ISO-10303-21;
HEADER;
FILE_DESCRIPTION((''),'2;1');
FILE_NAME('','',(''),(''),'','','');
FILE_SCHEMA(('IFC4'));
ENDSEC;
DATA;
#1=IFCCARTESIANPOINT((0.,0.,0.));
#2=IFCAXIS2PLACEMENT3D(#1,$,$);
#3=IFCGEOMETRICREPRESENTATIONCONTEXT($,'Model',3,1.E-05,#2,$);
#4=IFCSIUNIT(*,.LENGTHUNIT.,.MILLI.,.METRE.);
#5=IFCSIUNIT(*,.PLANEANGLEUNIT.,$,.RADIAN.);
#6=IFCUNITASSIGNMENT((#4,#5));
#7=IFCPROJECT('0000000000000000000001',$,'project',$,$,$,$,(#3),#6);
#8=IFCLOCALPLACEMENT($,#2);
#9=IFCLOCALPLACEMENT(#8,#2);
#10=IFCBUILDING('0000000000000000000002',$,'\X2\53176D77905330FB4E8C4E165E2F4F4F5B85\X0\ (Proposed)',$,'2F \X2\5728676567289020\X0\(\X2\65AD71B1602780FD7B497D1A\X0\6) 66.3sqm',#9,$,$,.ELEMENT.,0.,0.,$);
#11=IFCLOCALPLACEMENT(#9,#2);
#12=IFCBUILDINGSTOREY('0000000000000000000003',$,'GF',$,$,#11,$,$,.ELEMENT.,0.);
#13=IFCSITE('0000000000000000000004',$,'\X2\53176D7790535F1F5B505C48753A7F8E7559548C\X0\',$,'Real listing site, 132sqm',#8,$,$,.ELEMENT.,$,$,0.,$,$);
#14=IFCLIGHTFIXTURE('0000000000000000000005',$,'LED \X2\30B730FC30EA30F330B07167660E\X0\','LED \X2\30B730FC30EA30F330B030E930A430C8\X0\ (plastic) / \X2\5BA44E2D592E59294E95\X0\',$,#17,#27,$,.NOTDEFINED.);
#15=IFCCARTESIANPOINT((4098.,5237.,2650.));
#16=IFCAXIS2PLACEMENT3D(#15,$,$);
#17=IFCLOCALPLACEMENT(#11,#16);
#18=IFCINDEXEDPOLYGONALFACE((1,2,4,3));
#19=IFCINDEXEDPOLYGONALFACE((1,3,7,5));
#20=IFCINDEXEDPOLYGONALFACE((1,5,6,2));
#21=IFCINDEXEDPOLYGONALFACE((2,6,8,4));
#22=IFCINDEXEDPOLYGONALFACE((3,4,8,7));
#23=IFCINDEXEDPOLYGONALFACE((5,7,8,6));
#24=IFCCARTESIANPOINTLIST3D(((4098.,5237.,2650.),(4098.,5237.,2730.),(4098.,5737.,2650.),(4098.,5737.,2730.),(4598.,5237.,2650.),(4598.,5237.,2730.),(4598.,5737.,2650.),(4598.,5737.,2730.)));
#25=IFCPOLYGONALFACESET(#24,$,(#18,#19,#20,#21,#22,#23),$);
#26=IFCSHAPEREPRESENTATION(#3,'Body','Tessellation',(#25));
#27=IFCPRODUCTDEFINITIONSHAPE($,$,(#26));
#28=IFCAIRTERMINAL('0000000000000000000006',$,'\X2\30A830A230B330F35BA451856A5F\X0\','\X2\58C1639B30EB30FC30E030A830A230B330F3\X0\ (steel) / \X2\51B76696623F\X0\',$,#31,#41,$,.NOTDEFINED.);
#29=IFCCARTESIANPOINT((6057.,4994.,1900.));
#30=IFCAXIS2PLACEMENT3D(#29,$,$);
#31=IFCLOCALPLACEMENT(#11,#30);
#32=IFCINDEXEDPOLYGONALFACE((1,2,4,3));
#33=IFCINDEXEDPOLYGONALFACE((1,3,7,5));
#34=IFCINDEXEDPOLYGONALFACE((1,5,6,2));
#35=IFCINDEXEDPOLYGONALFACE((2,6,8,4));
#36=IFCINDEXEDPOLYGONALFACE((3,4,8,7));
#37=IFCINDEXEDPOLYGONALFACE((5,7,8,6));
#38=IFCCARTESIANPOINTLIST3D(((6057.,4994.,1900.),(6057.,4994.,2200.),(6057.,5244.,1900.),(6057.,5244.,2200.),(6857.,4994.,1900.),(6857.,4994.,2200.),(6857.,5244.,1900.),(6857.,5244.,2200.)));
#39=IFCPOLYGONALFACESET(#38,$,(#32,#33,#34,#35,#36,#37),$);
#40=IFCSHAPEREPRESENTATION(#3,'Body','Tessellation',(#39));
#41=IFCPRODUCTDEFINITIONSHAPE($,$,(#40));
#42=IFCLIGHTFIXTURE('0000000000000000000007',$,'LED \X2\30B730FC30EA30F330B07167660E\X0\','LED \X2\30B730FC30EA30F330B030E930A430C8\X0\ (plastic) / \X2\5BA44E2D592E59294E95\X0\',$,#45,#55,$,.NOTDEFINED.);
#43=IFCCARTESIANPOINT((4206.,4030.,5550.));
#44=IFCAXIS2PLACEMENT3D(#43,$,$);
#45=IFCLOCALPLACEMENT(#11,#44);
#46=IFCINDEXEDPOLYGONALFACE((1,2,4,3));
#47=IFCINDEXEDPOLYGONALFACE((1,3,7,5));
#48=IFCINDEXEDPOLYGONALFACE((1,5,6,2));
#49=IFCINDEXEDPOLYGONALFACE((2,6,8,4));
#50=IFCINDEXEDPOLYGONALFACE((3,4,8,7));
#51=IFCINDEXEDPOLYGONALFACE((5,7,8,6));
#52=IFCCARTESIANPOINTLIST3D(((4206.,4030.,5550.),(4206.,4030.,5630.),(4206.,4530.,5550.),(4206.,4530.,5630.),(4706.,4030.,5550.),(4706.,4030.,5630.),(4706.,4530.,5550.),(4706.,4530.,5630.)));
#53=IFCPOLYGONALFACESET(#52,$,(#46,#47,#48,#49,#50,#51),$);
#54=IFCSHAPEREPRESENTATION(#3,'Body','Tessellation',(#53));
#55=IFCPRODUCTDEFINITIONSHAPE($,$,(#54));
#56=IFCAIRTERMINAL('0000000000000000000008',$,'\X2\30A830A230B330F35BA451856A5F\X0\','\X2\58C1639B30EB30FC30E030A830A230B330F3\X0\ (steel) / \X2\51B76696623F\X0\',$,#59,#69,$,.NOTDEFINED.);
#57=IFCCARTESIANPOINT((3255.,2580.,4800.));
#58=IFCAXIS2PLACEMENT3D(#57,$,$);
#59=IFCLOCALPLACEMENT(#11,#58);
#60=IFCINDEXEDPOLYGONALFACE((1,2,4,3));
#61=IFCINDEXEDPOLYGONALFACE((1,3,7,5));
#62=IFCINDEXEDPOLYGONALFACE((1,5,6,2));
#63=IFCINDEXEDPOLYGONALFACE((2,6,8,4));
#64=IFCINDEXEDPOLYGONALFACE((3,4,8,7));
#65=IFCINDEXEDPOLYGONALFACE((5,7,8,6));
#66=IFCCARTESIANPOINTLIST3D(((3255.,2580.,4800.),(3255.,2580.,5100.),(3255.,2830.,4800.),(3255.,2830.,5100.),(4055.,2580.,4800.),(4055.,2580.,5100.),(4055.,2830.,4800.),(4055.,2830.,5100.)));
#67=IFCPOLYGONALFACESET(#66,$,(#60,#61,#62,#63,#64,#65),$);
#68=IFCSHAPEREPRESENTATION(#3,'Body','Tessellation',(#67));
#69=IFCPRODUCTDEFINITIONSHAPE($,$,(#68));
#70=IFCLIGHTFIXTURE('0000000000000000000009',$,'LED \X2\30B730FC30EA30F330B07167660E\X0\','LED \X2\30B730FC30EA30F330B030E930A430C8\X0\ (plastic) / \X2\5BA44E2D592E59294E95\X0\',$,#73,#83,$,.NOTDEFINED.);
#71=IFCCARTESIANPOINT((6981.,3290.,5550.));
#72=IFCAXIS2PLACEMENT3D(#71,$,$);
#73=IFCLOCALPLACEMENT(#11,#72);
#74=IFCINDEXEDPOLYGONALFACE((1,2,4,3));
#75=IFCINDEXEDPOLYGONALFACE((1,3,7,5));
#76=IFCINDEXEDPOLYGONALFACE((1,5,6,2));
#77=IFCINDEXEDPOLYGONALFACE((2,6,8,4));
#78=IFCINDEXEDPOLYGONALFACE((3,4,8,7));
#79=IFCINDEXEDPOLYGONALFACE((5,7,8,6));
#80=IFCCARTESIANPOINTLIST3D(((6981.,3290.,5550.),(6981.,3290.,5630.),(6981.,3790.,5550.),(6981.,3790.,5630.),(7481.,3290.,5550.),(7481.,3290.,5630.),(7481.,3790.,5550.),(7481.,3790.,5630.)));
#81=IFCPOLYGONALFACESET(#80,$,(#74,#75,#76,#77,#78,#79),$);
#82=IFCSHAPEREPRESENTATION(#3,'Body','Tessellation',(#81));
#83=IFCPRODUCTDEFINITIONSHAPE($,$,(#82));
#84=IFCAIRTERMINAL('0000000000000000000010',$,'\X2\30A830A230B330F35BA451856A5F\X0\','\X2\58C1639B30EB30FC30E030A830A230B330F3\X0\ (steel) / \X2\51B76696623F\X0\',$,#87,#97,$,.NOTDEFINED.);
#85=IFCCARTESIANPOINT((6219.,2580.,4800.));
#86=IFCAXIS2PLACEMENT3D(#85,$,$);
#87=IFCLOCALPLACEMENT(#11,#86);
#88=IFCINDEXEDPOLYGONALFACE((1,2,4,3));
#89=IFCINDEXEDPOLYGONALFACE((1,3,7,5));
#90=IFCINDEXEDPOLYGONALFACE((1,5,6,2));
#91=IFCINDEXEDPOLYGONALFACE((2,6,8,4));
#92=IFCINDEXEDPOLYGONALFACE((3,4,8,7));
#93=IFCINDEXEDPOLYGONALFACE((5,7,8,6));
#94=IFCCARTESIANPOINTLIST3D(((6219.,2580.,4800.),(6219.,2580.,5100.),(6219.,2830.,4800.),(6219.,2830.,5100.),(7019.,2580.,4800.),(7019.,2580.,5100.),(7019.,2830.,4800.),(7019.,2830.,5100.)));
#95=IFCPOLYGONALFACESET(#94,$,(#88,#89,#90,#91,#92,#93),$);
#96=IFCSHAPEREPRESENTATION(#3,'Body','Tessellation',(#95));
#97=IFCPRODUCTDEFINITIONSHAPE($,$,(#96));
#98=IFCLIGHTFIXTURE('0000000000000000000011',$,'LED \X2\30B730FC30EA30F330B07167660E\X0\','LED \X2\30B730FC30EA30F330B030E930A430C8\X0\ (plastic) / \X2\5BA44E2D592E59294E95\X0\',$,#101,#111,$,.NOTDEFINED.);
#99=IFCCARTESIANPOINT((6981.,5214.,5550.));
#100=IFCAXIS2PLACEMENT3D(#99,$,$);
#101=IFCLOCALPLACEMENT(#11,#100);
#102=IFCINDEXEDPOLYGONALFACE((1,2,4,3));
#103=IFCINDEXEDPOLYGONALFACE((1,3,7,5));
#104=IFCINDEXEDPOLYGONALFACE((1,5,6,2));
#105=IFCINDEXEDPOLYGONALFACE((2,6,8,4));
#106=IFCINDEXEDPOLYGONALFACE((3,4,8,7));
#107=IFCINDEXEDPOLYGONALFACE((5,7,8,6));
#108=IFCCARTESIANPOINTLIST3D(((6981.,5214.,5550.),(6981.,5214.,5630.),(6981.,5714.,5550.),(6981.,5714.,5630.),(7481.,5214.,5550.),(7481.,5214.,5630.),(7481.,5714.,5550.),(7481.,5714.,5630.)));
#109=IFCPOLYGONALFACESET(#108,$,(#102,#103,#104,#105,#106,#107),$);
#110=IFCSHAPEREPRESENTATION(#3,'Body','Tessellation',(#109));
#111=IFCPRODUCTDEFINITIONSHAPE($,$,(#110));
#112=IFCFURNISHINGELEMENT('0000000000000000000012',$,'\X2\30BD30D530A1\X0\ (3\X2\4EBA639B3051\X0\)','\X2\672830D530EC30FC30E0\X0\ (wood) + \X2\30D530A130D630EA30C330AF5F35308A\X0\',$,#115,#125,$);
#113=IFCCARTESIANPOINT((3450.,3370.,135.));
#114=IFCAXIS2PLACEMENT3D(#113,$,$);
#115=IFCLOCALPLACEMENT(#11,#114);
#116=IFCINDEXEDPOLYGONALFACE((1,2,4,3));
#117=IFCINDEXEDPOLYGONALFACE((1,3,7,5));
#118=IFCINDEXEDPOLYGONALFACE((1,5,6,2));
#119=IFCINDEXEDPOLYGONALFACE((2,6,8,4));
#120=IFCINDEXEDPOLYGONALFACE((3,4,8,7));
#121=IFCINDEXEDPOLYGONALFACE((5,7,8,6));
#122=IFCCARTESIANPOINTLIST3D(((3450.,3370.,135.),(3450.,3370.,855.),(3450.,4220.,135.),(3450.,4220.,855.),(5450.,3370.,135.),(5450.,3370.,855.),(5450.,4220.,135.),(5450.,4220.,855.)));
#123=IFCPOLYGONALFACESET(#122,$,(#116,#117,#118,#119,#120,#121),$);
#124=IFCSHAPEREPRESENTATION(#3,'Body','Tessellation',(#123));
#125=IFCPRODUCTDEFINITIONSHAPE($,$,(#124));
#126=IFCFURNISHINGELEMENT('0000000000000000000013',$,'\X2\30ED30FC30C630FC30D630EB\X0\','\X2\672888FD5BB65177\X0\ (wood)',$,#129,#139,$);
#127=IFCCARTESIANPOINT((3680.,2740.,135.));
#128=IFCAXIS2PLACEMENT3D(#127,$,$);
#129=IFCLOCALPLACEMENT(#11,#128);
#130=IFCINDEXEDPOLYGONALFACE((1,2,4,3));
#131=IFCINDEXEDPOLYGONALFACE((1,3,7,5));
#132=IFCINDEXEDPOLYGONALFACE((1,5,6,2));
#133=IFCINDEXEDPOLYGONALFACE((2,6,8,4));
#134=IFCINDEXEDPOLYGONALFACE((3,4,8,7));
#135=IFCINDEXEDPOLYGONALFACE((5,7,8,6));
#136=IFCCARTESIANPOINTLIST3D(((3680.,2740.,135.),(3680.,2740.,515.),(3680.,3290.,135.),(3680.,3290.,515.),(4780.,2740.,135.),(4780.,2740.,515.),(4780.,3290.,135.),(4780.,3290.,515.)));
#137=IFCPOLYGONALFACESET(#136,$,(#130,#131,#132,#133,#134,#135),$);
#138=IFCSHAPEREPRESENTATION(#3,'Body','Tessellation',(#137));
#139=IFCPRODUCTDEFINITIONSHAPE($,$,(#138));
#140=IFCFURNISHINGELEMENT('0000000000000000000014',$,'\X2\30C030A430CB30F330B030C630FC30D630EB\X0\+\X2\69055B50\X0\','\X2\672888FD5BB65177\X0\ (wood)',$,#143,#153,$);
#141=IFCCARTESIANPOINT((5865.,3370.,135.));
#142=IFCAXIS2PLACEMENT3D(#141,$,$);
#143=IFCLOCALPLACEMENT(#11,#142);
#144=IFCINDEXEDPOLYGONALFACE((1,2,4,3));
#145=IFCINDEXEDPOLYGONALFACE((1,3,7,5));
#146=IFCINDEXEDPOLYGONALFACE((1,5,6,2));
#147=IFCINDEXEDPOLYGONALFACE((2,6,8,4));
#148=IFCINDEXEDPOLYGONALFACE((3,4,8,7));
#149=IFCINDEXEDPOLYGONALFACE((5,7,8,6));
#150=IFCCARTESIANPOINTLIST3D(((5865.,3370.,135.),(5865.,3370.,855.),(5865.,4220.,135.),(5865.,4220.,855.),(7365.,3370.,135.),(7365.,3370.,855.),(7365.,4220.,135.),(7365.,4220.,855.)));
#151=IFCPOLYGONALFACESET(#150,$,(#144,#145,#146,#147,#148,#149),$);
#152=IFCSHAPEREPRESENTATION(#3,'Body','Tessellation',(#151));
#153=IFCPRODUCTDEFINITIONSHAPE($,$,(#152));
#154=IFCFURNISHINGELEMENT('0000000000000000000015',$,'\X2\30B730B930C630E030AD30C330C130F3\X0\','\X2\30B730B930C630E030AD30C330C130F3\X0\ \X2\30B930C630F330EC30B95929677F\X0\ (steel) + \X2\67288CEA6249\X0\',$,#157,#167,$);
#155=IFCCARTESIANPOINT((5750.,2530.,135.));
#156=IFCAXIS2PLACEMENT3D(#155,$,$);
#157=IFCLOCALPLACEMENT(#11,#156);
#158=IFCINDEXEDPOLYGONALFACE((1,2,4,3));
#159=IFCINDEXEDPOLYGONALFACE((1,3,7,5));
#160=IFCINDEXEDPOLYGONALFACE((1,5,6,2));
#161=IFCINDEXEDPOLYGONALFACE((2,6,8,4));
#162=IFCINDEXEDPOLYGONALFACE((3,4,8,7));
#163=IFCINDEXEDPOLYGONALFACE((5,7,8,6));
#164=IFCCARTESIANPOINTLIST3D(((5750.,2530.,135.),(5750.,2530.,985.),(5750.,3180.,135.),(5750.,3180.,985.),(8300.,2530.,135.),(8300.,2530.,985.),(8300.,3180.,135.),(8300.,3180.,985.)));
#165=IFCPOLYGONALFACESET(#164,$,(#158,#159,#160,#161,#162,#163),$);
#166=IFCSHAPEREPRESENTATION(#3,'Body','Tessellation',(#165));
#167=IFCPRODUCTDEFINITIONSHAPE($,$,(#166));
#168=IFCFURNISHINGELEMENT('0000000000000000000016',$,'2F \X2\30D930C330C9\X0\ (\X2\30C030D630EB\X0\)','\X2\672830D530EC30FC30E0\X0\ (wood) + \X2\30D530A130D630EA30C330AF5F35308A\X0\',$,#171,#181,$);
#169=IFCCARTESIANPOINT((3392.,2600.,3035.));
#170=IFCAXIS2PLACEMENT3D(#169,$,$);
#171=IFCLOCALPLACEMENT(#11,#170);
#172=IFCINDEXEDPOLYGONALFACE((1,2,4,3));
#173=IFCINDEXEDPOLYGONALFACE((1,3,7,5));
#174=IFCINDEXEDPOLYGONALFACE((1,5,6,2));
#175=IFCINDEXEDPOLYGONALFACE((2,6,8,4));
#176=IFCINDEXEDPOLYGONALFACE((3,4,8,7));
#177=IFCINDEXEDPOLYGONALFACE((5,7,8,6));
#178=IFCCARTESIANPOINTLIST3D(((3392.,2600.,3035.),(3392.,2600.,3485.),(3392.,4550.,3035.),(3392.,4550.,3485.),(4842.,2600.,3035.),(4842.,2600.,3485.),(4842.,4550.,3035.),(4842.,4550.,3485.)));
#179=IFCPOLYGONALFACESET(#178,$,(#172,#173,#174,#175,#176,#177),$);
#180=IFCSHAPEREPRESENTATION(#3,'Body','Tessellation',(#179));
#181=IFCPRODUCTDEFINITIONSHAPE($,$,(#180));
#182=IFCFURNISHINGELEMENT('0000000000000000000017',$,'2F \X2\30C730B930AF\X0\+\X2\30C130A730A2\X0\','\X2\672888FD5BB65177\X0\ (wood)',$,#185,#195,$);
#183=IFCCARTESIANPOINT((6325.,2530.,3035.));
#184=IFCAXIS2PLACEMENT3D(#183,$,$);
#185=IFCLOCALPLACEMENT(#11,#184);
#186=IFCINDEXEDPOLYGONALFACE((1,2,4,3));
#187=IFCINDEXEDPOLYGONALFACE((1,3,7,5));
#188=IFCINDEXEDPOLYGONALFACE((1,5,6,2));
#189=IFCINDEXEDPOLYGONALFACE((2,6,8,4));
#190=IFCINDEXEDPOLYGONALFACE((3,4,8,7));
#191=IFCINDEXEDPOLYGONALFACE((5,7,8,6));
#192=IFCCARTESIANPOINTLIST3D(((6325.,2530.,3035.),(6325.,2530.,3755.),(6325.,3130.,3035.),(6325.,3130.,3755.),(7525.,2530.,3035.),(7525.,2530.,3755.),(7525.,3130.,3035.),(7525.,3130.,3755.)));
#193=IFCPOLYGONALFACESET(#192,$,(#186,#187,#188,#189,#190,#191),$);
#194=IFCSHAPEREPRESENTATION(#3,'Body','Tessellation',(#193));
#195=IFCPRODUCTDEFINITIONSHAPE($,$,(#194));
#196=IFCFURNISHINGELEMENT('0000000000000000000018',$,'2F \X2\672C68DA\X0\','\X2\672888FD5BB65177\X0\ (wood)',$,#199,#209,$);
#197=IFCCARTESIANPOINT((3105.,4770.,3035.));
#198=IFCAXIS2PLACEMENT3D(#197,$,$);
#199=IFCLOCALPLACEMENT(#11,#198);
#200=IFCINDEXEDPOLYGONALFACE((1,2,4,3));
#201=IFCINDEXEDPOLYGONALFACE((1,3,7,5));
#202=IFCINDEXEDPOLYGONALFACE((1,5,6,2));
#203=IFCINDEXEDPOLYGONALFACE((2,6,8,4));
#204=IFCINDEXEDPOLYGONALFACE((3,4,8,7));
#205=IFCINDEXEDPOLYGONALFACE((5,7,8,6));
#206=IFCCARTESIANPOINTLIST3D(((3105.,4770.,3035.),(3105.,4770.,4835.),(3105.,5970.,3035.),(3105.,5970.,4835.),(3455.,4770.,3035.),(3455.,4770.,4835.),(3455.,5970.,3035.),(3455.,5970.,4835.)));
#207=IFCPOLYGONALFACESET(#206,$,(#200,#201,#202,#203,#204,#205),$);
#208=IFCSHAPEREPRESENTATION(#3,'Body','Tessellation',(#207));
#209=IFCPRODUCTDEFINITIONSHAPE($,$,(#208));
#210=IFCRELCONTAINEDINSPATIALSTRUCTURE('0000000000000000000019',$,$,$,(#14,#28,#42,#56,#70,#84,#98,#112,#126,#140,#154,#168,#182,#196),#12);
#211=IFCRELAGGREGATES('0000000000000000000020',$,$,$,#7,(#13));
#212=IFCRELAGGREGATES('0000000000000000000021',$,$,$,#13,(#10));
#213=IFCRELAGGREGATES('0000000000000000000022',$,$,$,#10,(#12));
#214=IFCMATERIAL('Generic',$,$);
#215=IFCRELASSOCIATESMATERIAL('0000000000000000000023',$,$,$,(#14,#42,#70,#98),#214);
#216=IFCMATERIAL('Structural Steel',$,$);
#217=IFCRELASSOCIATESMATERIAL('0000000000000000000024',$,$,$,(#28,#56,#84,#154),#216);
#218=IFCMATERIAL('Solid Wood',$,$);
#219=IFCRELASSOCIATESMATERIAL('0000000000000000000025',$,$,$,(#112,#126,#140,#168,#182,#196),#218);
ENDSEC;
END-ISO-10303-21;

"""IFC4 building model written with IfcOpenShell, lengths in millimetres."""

from ifc_helpers import new_model, si_unit, frame, frame_2d, origin, place, context, project, spatial, rectangle, extrude, material, element, save


model = new_model("IFC4")

# Units and contexts
model_context = context("Model", 3, precision=1e-05, world=origin())
ifc_project = project(units=[si_unit("LENGTHUNIT", "METRE", prefix="MILLI"), si_unit("PLANEANGLEUNIT", "RADIAN")], contexts=[model_context])

# Site, building, storey
site_placement = place(None, origin())
site = spatial("IfcSite", under=ifc_project, at=site_placement, Name="北海道弟子屈町美留和", ObjectType="Real listing site, 132sqm", CompositionType="ELEMENT", RefElevation=0.0)
building_placement = place(site_placement, origin())
building = spatial("IfcBuilding", under=site, at=building_placement, Name="北海道・二世帯住宅 (Proposed)", ObjectType="2F 在来木造(断熱性能等級6) 66.3sqm", CompositionType="ELEMENT", ElevationOfRefHeight=0.0, ElevationOfTerrain=0.0)
storey_placement = place(building_placement, origin())
storey = spatial("IfcBuildingStorey", under=building, at=storey_placement, Name="GF", CompositionType="ELEMENT", Elevation=0.0)

# Shared definitions
ifc_material_1 = material(Name="Solid Wood")

# Shared definitions
ifc_material_2 = material(Name="Structural Steel")

# Shared definitions
ifc_material_3 = material(Name="Generic")

# Light fixture
light_fixture_1_placement = place(storey_placement, frame((4098.0, 5237.0, 2650.0)))
element("IfcLightFixture", 1, at=light_fixture_1_placement, inside=storey, material=ifc_material_3, Name="LED シーリング照明", Description="LED シーリングライト (plastic) / 室中央天井", PredefinedType="NOTDEFINED", context=model_context, shape_type="SweptSolid", body=[
    extrude(rectangle(XDim=500.0, YDim=500.0, at=frame_2d((250.0, 250.0))), frame((4098.0, 5237.0, 2650.0)), (0.0, 0.0, 1.0), 80.0),
])

# Air terminal
air_terminal_1_placement = place(storey_placement, frame((6057.0, 4994.0, 1900.0)))
element("IfcAirTerminal", 2, at=air_terminal_1_placement, inside=storey, material=ifc_material_2, Name="エアコン室内機", Description="壁掛ルームエアコン (steel) / 冷暖房", PredefinedType="NOTDEFINED", context=model_context, shape_type="SweptSolid", body=[
    extrude(rectangle(XDim=800.0, YDim=250.0, at=frame_2d((400.0, 125.0))), frame((6057.0, 4994.0, 1900.0)), (0.0, 0.0, 1.0), 300.0),
])

# Light fixture
light_fixture_2_placement = place(storey_placement, frame((4206.0, 4030.0, 5550.0)))
element("IfcLightFixture", 3, at=light_fixture_2_placement, inside=storey, material=ifc_material_3, Name="LED シーリング照明", Description="LED シーリングライト (plastic) / 室中央天井", PredefinedType="NOTDEFINED", context=model_context, shape_type="SweptSolid", body=[
    extrude(rectangle(XDim=500.0, YDim=500.0, at=frame_2d((250.0, 250.0))), frame((4206.0, 4030.0, 5550.0)), (0.0, 0.0, 1.0), 80.0),
])

# Air terminal
air_terminal_2_placement = place(storey_placement, frame((3255.0, 2580.0, 4800.0)))
element("IfcAirTerminal", 4, at=air_terminal_2_placement, inside=storey, material=ifc_material_2, Name="エアコン室内機", Description="壁掛ルームエアコン (steel) / 冷暖房", PredefinedType="NOTDEFINED", context=model_context, shape_type="SweptSolid", body=[
    extrude(rectangle(XDim=800.0, YDim=250.0, at=frame_2d((400.0, 125.0))), frame((3255.0, 2580.0, 4800.0)), (0.0, 0.0, 1.0), 300.0),
])

# Light fixture
light_fixture_3_placement = place(storey_placement, frame((6981.0, 3290.0, 5550.0)))
element("IfcLightFixture", 5, at=light_fixture_3_placement, inside=storey, material=ifc_material_3, Name="LED シーリング照明", Description="LED シーリングライト (plastic) / 室中央天井", PredefinedType="NOTDEFINED", context=model_context, shape_type="SweptSolid", body=[
    extrude(rectangle(XDim=500.0, YDim=500.0, at=frame_2d((250.0, 250.0))), frame((6981.0, 3290.0, 5550.0)), (0.0, 0.0, 1.0), 80.0),
])

# Air terminal
air_terminal_3_placement = place(storey_placement, frame((6219.0, 2580.0, 4800.0)))
element("IfcAirTerminal", 6, at=air_terminal_3_placement, inside=storey, material=ifc_material_2, Name="エアコン室内機", Description="壁掛ルームエアコン (steel) / 冷暖房", PredefinedType="NOTDEFINED", context=model_context, shape_type="SweptSolid", body=[
    extrude(rectangle(XDim=800.0, YDim=250.0, at=frame_2d((400.0, 125.0))), frame((6219.0, 2580.0, 4800.0)), (0.0, 0.0, 1.0), 300.0),
])

# Light fixture
light_fixture_4_placement = place(storey_placement, frame((6981.0, 5214.0, 5550.0)))
element("IfcLightFixture", 7, at=light_fixture_4_placement, inside=storey, material=ifc_material_3, Name="LED シーリング照明", Description="LED シーリングライト (plastic) / 室中央天井", PredefinedType="NOTDEFINED", context=model_context, shape_type="SweptSolid", body=[
    extrude(rectangle(XDim=500.0, YDim=500.0, at=frame_2d((250.0, 250.0))), frame((6981.0, 5214.0, 5550.0)), (0.0, 0.0, 1.0), 80.0),
])

# Furnishing elements
furnishing_1_placement = place(storey_placement, frame((3450.0, 3370.0, 135.0)))
element("IfcFurnishingElement", 8, at=furnishing_1_placement, inside=storey, material=ifc_material_1, Name="ソファ (3人掛け)", Description="木フレーム (wood) + ファブリック張り", context=model_context, shape_type="SweptSolid", body=[
    extrude(rectangle(XDim=2000.0, YDim=850.0, at=frame_2d((1000.0, 425.0))), frame((3450.0, 3370.0, 135.0)), (0.0, 0.0, 1.0), 720.0),
])
furnishing_2_placement = place(storey_placement, frame((3680.0, 2740.0, 135.0)))
element("IfcFurnishingElement", 9, at=furnishing_2_placement, inside=storey, material=ifc_material_1, Name="ローテーブル", Description="木製家具 (wood)", context=model_context, shape_type="SweptSolid", body=[
    extrude(rectangle(XDim=1100.0, YDim=550.0, at=frame_2d((550.0, 275.0))), frame((3680.0, 2740.0, 135.0)), (0.0, 0.0, 1.0), 380.0),
])
furnishing_3_placement = place(storey_placement, frame((5865.0, 3370.0, 135.0)))
element("IfcFurnishingElement", 10, at=furnishing_3_placement, inside=storey, material=ifc_material_1, Name="ダイニングテーブル+椅子", Description="木製家具 (wood)", context=model_context, shape_type="SweptSolid", body=[
    extrude(rectangle(XDim=1500.0, YDim=850.0, at=frame_2d((750.0, 425.0))), frame((5865.0, 3370.0, 135.0)), (0.0, 0.0, 1.0), 720.0),
])
furnishing_4_placement = place(storey_placement, frame((5750.0, 2530.0, 135.0)))
element("IfcFurnishingElement", 11, at=furnishing_4_placement, inside=storey, material=ifc_material_2, Name="システムキッチン", Description="システムキッチン ステンレス天板 (steel) + 木質扉", context=model_context, shape_type="SweptSolid", body=[
    extrude(rectangle(XDim=2550.0, YDim=650.0, at=frame_2d((1275.0, 325.0))), frame((5750.0, 2530.0, 135.0)), (0.0, 0.0, 1.0), 850.0),
])
furnishing_5_placement = place(storey_placement, frame((3392.0, 2600.0, 3035.0)))
element("IfcFurnishingElement", 12, at=furnishing_5_placement, inside=storey, material=ifc_material_1, Name="2F ベッド (ダブル)", Description="木フレーム (wood) + ファブリック張り", context=model_context, shape_type="SweptSolid", body=[
    extrude(rectangle(XDim=1450.0, YDim=1950.0, at=frame_2d((725.0, 975.0))), frame((3392.0, 2600.0, 3035.0)), (0.0, 0.0, 1.0), 450.0),
])
furnishing_6_placement = place(storey_placement, frame((6325.0, 2530.0, 3035.0)))
element("IfcFurnishingElement", 13, at=furnishing_6_placement, inside=storey, material=ifc_material_1, Name="2F デスク+チェア", Description="木製家具 (wood)", context=model_context, shape_type="SweptSolid", body=[
    extrude(rectangle(XDim=1200.0, YDim=600.0, at=frame_2d((600.0, 300.0))), frame((6325.0, 2530.0, 3035.0)), (0.0, 0.0, 1.0), 720.0),
])
furnishing_7_placement = place(storey_placement, frame((3105.0, 4770.0, 3035.0)))
element("IfcFurnishingElement", 14, at=furnishing_7_placement, inside=storey, material=ifc_material_1, Name="2F 本棚", Description="木製家具 (wood)", context=model_context, shape_type="SweptSolid", body=[
    extrude(rectangle(XDim=350.0, YDim=1200.0, at=frame_2d((175.0, 600.0))), frame((3105.0, 4770.0, 3035.0)), (0.0, 0.0, 1.0), 1800.0),
])

save(model, "model.ifc")
